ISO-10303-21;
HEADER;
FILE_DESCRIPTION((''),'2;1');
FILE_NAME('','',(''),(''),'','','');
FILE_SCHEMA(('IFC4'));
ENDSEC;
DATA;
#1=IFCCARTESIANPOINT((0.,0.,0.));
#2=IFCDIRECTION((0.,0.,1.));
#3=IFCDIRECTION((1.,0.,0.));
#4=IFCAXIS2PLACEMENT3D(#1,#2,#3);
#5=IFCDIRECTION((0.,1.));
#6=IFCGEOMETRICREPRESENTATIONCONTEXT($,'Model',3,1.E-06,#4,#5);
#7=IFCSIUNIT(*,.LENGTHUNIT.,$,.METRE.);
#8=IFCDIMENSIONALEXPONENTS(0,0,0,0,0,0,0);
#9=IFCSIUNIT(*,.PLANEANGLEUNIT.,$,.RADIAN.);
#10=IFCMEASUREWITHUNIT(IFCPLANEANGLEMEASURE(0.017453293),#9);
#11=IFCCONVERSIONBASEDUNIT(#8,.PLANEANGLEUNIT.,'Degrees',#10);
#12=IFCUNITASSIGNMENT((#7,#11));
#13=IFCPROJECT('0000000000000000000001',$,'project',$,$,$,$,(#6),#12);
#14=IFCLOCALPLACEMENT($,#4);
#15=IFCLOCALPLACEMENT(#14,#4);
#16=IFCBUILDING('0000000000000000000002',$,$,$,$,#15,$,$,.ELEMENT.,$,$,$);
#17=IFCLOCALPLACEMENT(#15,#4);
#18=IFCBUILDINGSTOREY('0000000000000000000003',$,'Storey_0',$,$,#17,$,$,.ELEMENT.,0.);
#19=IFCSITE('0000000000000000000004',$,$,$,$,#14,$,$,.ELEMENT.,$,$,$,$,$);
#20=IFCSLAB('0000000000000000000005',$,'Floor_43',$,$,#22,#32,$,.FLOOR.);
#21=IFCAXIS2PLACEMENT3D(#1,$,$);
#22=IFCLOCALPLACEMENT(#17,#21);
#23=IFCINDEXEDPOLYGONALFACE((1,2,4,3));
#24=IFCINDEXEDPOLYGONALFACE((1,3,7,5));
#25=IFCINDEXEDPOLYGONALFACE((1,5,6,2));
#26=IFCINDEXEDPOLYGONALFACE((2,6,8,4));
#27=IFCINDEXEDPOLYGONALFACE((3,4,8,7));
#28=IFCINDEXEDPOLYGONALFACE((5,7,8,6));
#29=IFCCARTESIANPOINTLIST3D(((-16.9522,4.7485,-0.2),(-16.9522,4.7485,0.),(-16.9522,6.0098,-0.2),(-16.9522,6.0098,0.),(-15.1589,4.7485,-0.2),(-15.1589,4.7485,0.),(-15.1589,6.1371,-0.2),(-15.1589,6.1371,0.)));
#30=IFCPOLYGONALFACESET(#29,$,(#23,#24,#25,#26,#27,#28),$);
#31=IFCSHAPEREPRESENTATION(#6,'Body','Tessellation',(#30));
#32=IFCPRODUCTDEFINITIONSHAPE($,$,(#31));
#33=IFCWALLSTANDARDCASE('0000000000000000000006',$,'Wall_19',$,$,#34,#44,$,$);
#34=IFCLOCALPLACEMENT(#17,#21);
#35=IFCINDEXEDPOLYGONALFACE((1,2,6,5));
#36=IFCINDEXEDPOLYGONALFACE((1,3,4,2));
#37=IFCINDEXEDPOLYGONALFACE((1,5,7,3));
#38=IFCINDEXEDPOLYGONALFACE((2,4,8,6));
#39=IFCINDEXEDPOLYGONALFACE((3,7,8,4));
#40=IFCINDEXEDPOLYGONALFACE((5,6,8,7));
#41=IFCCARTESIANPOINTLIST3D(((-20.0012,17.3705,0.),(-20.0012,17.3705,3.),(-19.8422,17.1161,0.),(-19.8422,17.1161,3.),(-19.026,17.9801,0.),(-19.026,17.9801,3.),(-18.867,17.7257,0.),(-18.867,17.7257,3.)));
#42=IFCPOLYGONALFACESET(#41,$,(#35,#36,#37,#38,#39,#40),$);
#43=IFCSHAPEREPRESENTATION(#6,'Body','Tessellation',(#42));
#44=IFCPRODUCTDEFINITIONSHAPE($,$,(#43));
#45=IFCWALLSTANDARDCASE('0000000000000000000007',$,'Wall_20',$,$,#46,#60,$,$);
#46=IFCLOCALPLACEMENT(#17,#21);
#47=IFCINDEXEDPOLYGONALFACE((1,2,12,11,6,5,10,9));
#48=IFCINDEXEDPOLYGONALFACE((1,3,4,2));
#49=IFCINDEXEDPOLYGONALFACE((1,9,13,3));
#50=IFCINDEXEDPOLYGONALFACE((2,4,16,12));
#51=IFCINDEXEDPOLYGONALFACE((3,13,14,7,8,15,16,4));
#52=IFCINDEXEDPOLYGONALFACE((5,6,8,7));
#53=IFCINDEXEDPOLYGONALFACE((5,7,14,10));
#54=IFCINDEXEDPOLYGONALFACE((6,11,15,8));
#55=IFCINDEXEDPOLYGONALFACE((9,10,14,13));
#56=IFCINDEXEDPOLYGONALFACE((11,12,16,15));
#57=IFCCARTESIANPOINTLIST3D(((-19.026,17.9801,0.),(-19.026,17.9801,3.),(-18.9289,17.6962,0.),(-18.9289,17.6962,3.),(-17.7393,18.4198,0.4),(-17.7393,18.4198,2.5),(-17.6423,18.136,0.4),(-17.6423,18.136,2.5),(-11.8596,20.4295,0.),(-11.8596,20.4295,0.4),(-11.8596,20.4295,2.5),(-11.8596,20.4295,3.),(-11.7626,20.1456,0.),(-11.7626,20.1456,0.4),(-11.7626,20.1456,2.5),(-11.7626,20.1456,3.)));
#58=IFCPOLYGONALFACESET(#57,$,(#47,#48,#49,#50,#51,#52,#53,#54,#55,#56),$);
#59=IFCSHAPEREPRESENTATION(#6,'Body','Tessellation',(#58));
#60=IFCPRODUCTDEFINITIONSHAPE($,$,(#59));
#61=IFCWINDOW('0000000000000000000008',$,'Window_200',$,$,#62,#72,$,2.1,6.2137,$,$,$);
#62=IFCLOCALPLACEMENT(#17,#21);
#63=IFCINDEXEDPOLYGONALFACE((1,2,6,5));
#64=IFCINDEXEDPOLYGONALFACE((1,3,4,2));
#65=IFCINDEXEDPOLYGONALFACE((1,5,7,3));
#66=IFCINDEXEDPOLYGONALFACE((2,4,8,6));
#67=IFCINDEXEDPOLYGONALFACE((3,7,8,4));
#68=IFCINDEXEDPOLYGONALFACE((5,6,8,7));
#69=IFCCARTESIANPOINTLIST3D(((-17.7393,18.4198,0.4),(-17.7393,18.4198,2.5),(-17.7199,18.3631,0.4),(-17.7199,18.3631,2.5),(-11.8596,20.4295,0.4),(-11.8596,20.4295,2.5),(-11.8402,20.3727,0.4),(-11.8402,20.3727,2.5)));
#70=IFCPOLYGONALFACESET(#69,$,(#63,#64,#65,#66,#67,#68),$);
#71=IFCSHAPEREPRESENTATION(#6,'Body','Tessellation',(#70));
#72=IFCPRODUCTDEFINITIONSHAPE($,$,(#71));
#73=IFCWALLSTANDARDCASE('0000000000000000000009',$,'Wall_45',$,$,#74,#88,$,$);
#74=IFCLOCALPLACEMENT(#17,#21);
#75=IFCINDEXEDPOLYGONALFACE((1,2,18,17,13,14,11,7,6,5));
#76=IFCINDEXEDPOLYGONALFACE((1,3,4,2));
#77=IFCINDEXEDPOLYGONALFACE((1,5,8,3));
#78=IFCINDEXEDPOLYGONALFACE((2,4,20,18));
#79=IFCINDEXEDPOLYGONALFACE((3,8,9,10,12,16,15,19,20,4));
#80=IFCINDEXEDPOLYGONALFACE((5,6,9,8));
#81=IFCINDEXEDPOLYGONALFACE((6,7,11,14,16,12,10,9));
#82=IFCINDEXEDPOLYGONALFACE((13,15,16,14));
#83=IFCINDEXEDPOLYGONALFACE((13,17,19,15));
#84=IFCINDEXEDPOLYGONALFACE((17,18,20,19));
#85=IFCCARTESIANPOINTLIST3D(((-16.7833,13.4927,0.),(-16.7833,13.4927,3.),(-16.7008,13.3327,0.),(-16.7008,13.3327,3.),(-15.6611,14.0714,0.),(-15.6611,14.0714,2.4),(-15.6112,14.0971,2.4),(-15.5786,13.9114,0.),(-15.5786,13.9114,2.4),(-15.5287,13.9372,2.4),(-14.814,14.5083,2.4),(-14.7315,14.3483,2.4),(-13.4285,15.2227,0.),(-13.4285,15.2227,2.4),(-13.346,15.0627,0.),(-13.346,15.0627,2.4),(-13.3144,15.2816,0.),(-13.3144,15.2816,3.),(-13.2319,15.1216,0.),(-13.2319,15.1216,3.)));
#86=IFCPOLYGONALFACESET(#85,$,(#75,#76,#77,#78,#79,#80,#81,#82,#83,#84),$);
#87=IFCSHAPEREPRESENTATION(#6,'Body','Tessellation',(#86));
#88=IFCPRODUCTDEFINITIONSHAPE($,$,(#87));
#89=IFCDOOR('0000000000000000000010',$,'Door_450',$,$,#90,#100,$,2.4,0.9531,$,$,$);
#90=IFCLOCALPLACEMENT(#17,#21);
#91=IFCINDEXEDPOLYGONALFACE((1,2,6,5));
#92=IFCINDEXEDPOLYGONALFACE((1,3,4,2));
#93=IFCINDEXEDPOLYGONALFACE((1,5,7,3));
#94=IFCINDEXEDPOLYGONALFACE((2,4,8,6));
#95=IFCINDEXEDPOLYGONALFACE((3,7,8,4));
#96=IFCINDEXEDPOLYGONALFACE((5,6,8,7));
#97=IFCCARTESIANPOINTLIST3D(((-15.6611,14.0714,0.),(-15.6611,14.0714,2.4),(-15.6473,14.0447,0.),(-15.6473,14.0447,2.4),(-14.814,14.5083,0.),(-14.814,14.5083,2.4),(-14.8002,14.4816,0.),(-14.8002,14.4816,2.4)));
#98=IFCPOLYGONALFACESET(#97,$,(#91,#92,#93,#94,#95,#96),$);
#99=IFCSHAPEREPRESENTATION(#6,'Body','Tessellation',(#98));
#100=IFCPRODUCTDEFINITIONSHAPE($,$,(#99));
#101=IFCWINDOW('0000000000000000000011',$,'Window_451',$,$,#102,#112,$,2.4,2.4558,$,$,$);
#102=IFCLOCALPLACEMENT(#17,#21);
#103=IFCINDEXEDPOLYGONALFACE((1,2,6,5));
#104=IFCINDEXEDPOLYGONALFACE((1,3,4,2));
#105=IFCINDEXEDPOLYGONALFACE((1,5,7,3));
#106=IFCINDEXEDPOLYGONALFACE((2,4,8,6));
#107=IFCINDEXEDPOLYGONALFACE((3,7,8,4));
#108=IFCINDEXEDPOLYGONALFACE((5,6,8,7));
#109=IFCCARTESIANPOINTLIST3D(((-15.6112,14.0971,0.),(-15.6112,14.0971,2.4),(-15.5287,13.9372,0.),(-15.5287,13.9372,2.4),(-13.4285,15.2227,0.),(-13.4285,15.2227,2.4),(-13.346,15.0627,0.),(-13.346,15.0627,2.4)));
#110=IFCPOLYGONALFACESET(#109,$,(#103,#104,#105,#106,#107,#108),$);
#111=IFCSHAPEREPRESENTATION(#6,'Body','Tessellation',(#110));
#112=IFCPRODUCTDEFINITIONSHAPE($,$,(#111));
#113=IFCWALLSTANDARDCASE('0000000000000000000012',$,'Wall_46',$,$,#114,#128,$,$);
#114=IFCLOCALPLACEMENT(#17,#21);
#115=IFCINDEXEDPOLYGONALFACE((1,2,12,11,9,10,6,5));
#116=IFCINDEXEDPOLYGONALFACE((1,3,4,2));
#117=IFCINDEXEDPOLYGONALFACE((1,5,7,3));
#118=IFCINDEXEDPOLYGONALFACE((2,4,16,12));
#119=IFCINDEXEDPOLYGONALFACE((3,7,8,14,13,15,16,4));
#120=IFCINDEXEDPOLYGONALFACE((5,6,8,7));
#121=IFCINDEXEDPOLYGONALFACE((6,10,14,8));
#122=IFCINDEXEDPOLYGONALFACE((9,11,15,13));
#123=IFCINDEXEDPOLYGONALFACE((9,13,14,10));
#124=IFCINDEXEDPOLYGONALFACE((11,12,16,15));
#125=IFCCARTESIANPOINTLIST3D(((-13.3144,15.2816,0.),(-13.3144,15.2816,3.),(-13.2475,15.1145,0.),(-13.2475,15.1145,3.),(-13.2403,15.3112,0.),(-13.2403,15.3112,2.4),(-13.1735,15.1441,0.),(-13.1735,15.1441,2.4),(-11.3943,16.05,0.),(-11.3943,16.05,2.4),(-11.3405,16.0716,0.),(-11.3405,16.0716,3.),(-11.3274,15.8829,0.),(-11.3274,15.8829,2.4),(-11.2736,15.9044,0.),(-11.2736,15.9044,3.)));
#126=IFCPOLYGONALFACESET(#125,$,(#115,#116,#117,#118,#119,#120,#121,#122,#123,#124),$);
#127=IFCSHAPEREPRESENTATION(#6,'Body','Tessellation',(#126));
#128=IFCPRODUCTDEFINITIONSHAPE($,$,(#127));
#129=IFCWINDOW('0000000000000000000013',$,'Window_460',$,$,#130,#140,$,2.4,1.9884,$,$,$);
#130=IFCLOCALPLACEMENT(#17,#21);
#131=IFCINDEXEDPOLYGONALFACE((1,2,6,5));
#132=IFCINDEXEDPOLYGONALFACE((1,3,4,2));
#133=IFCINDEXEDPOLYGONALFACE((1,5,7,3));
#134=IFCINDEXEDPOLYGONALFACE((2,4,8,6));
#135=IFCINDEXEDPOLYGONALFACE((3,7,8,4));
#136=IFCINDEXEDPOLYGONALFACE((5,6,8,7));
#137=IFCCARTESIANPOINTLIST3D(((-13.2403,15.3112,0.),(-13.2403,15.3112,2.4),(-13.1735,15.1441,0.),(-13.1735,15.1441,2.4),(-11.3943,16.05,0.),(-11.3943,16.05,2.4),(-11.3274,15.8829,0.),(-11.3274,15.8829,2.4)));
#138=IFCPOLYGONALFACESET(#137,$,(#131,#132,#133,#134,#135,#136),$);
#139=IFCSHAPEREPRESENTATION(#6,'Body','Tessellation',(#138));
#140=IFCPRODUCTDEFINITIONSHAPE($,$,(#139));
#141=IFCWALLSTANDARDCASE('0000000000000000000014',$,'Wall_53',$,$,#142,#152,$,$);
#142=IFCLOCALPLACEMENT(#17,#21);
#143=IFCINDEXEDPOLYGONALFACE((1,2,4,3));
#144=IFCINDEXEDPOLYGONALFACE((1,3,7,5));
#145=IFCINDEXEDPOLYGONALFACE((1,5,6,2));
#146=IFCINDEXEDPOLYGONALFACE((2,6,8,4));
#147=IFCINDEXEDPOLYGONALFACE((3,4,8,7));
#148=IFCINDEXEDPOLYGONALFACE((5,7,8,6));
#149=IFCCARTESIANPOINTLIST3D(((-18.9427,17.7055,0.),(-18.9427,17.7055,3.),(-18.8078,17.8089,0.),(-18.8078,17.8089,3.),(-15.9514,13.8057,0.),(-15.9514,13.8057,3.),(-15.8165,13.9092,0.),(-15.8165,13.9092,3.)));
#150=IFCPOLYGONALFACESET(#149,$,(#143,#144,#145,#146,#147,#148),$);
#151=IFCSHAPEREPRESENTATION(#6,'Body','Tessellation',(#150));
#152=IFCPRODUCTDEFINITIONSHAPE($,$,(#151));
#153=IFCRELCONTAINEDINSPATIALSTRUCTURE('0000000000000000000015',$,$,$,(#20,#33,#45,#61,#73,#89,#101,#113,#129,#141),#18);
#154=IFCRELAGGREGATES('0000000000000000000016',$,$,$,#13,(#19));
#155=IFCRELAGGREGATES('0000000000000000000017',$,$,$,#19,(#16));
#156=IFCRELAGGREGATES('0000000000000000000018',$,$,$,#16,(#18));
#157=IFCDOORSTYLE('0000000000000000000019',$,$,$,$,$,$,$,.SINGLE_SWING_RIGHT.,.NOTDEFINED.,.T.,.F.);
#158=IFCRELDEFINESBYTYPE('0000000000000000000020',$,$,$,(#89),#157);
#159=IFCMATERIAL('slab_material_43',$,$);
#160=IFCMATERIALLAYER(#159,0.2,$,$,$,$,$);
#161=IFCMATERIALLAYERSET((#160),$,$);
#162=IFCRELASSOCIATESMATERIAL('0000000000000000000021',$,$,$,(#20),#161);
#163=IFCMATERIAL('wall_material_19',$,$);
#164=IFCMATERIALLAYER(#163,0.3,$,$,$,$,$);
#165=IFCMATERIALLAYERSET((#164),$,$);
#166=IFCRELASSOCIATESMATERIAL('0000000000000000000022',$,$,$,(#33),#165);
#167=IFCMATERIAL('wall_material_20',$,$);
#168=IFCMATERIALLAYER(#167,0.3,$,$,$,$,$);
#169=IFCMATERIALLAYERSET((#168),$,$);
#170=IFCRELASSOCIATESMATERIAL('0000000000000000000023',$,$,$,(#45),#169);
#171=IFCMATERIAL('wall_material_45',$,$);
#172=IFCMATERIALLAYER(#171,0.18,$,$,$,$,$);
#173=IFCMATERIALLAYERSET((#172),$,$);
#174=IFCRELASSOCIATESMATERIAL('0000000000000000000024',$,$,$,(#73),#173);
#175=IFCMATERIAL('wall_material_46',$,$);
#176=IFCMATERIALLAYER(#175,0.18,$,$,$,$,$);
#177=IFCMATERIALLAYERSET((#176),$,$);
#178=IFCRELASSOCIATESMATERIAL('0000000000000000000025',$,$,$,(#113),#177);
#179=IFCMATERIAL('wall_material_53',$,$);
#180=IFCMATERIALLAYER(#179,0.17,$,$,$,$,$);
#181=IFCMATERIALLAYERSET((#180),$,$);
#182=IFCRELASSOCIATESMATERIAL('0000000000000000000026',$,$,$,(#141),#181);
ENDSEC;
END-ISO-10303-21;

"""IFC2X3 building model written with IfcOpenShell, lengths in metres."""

from ifc_helpers import new_model, entity, si_unit, converted_unit, direction, frame, frame_2d, origin_with_axes, place, context, project, spatial, polyline, rectangle, outline, extrude, material, layer, layer_set, layer_usage, type_object, element, fill, save


model = new_model("IFC2X3")

# Units and contexts
model_context = context("Model", 3, precision=1e-06, world=origin_with_axes(), true_north=direction((0.0, 1.0)))
ifc_project = project(units=[si_unit("LENGTHUNIT", "METRE"), converted_unit("PLANEANGLEUNIT", "Degrees", entity("IfcPlaneAngleMeasure", 0.017453293), si_unit("PLANEANGLEUNIT", "RADIAN"), dimensions=[0, 0, 0, 0, 0, 0, 0])], contexts=[model_context])

# Site, building, storey
site_placement = place(None, origin_with_axes())
site = spatial("IfcSite", under=ifc_project, at=site_placement, CompositionType="ELEMENT")
building_placement = place(site_placement, origin_with_axes())
building = spatial("IfcBuilding", under=site, at=building_placement, CompositionType="ELEMENT")
storey_placement = place(building_placement, origin_with_axes())
storey = spatial("IfcBuildingStorey", under=building, at=storey_placement, Name="Storey_0", CompositionType="ELEMENT", Elevation=0.0)

# Slab
ifc_material_1 = material(Name="slab_material_43")
ifc_layer_1 = layer(ifc_material_1, 0.2)
ifc_layer_set_1 = layer_set([ifc_layer_1])
ifc_layer_usage_1 = layer_usage(ifc_layer_set_1, "AXIS3", "POSITIVE", 0.0)
slab_1_placement = place(storey_placement, frame((-16.0556, 5.4428, -0.2), z_axis=(0.0, 0.0, 1.0), x_axis=(1.0, 0.0, 0.0)))
element("IfcSlab", 1, at=slab_1_placement, inside=storey, material=ifc_layer_usage_1, Name="Floor_43", PredefinedType="FLOOR", context=model_context, shape_type="SweptSolid", body=[
    extrude(outline(polyline([(0.8967, -0.6943), (-0.8967, -0.6943), (-0.8967, 0.567), (0.8967, 0.6943), (0.8967, -0.6943)])), origin_with_axes(), (0.0, 0.0, 1.0), 0.2),
])

# Wall
ifc_material_2 = material(Name="wall_material_19")
ifc_layer_2 = layer(ifc_material_2, 0.3)
ifc_layer_set_2 = layer_set([ifc_layer_2])
ifc_layer_usage_2 = layer_usage(ifc_layer_set_2, "AXIS2", "NEGATIVE", 0.0)
wall_1_placement = place(storey_placement, frame((-20.0012, 17.3705, 0.0), z_axis=(0.0, 0.0, 1.0), x_axis=(0.847956, 0.530067, 0.0)))
element("IfcWallStandardCase", 2, at=wall_1_placement, inside=storey, material=ifc_layer_usage_2, Name="Wall_19", context=model_context, shape_type="SweptSolid", body=[
    extrude(outline(polyline([(0.0, 0.0), (1.1501, 0.0), (1.1501, -0.3), (0.0, -0.3), (0.0, 0.0)])), origin_with_axes(), (0.0, 0.0, 1.0), 3.0),
])

# Wall, opening, window
ifc_material_3 = material(Name="wall_material_20")
ifc_layer_3 = layer(ifc_material_3, 0.3)
ifc_layer_set_3 = layer_set([ifc_layer_3])
ifc_layer_usage_3 = layer_usage(ifc_layer_set_3, "AXIS2", "NEGATIVE", 0.0)
wall_2_placement = place(storey_placement, frame((-19.026, 17.9801, 0.0), z_axis=(0.0, 0.0, 1.0), x_axis=(0.946255, 0.323422, 0.0)))
wall_2 = element("IfcWallStandardCase", 3, at=wall_2_placement, inside=storey, material=ifc_layer_usage_3, Name="Wall_20", context=model_context, shape_type="SweptSolid", body=[
    extrude(outline(polyline([(0.0, 0.0), (7.5734, 0.0), (7.5734, -0.3), (0.0, -0.3), (0.0, 0.0)])), origin_with_axes(), (0.0, 0.0, 1.0), 3.0),
])
opening_1_placement = place(wall_2_placement, frame((1.3597, 0.0, 0.4), z_axis=(0.0, 0.0, 1.0), x_axis=(1.0, 0.0, 0.0)))
opening_1 = element("IfcOpeningElement", 4, at=opening_1_placement, cuts=wall_2, context=model_context, shape_type="SweptSolid", body=[
    extrude(rectangle(XDim=6.2137, YDim=2.1, at=frame_2d((1.05, -3.1069), x_axis=(0.0, 1.0))), frame((0.0, 0.01, 0.0), z_axis=(0.0, -1.0, 0.0), x_axis=(0.0, 0.0, 1.0)), (0.0, 0.0, 1.0), 0.32),
])
window_1_placement = place(storey_placement, frame((0.0, 0.0, 0.4), z_axis=(0.0, 0.0, 1.0), x_axis=(1.0, 0.0, 0.0)))
window_1 = element("IfcWindow", 5, at=window_1_placement, inside=storey, Name="Window_200", OverallHeight=2.1, OverallWidth=6.2137, context=model_context, shape_type="SweptSolid", body=[
    extrude(outline(polyline([(-17.7393, 18.4198), (-11.8596, 20.4295), (-11.8402, 20.3727), (-17.7199, 18.3631), (-17.7393, 18.4198)])), origin_with_axes(), (0.0, 0.0, 1.0), 2.1),
])
fill(opening_1, window_1)

# Wall, openings, door, window
ifc_material_4 = material(Name="wall_material_45")
ifc_layer_4 = layer(ifc_material_4, 0.18)
ifc_layer_set_4 = layer_set([ifc_layer_4])
ifc_layer_usage_4 = layer_usage(ifc_layer_set_4, "AXIS2", "POSITIVE", 0.0)
wall_3_placement = place(storey_placement, frame((-16.7008, 13.3327, 0.0), z_axis=(0.0, 0.0, 1.0), x_axis=(0.888777, 0.458339, 0.0)))
wall_3 = element("IfcWallStandardCase", 6, at=wall_3_placement, inside=storey, material=ifc_layer_usage_4, Name="Wall_45", context=model_context, shape_type="SweptSolid", body=[
    extrude(outline(polyline([(0.0, 0.18), (3.903, 0.18), (3.903, 0.0), (0.0, 0.0), (0.0, 0.18)])), origin_with_axes(), (0.0, 0.0, 1.0), 3.0),
])
opening_2_placement = place(wall_3_placement, frame((1.2627, 0.18, 0.0), z_axis=(0.0, 0.0, 1.0), x_axis=(1.0, 0.0, 0.0)))
opening_2 = element("IfcOpeningElement", 7, at=opening_2_placement, cuts=wall_3, context=model_context, shape_type="SweptSolid", body=[
    extrude(rectangle(XDim=0.9531, YDim=2.4, at=frame_2d((1.2, -0.4766), x_axis=(0.0, 1.0))), frame((0.0, 0.01, 0.0), z_axis=(0.0, -1.0, 0.0), x_axis=(0.0, 0.0, 1.0)), (0.0, 0.0, 1.0), 0.2),
])
opening_3_placement = place(wall_3_placement, frame((1.3188, 0.18, 0.0), z_axis=(0.0, 0.0, 1.0), x_axis=(1.0, 0.0, 0.0)))
opening_3 = element("IfcOpeningElement", 8, at=opening_3_placement, cuts=wall_3, context=model_context, shape_type="SweptSolid", body=[
    extrude(rectangle(XDim=2.4558, YDim=2.4, at=frame_2d((1.2, -1.2279), x_axis=(0.0, 1.0))), frame((0.0, 0.01, 0.0), z_axis=(0.0, -1.0, 0.0), x_axis=(0.0, 0.0, 1.0)), (0.0, 0.0, 1.0), 0.2),
])
door_style_1 = type_object("IfcDoorStyle", ConstructionType="NOTDEFINED", OperationType="SINGLE_SWING_RIGHT", ParameterTakesPrecedence=True, Sizeable=False)
door_1_placement = place(storey_placement, origin_with_axes())
door_1 = element("IfcDoor", 9, at=door_1_placement, inside=storey, type_object=door_style_1, Name="Door_450", OverallHeight=2.4, OverallWidth=0.9531, context=model_context, shape_type="SweptSolid", body=[
    extrude(outline(polyline([(-15.6611, 14.0714), (-14.814, 14.5083), (-14.8002, 14.4816), (-15.6473, 14.0447), (-15.6611, 14.0714)])), origin_with_axes(), (0.0, 0.0, 1.0), 2.4),
])
fill(opening_2, door_1)
window_2_placement = place(storey_placement, origin_with_axes())
window_2 = element("IfcWindow", 10, at=window_2_placement, inside=storey, Name="Window_451", OverallHeight=2.4, OverallWidth=2.4558, context=model_context, shape_type="SweptSolid", body=[
    extrude(outline(polyline([(-15.6112, 14.0971), (-13.4285, 15.2227), (-13.346, 15.0627), (-15.5287, 13.9372), (-15.6112, 14.0971)])), origin_with_axes(), (0.0, 0.0, 1.0), 2.4),
])
fill(opening_3, window_2)

# Wall, opening, window
ifc_material_5 = material(Name="wall_material_46")
ifc_layer_5 = layer(ifc_material_5, 0.18)
ifc_layer_set_5 = layer_set([ifc_layer_5])
ifc_layer_usage_5 = layer_usage(ifc_layer_set_5, "AXIS2", "POSITIVE", 0.0)
wall_4_placement = place(storey_placement, frame((-13.2475, 15.1145, 0.0), z_axis=(0.0, 0.0, 1.0), x_axis=(0.92841, 0.371557, 0.0)))
wall_4 = element("IfcWallStandardCase", 11, at=wall_4_placement, inside=storey, material=ifc_layer_usage_5, Name="Wall_46", context=model_context, shape_type="SweptSolid", body=[
    extrude(outline(polyline([(0.0, 0.18), (2.1261, 0.18), (2.1261, 0.0), (0.0, 0.0), (0.0, 0.18)])), origin_with_axes(), (0.0, 0.0, 1.0), 3.0),
])
opening_4_placement = place(wall_4_placement, frame((0.0798, 0.18, 0.0), z_axis=(0.0, 0.0, 1.0), x_axis=(1.0, 0.0, 0.0)))
opening_4 = element("IfcOpeningElement", 12, at=opening_4_placement, cuts=wall_4, context=model_context, shape_type="SweptSolid", body=[
    extrude(rectangle(XDim=1.9884, YDim=2.4, at=frame_2d((1.2, -0.9942), x_axis=(0.0, 1.0))), frame((0.0, 0.01, 0.0), z_axis=(0.0, -1.0, 0.0), x_axis=(0.0, 0.0, 1.0)), (0.0, 0.0, 1.0), 0.2),
])
window_3_placement = place(storey_placement, origin_with_axes())
window_3 = element("IfcWindow", 13, at=window_3_placement, inside=storey, Name="Window_460", OverallHeight=2.4, OverallWidth=1.9884, context=model_context, shape_type="SweptSolid", body=[
    extrude(outline(polyline([(-13.2403, 15.3112), (-11.3943, 16.05), (-11.3274, 15.8829), (-13.1735, 15.1441), (-13.2403, 15.3112)])), origin_with_axes(), (0.0, 0.0, 1.0), 2.4),
])
fill(opening_4, window_3)

# Wall
ifc_material_6 = material(Name="wall_material_53")
ifc_layer_6 = layer(ifc_material_6, 0.17)
ifc_layer_set_6 = layer_set([ifc_layer_6])
ifc_layer_usage_6 = layer_usage(ifc_layer_set_6, "AXIS2", "NEGATIVE", 0.0)
wall_5_placement = place(storey_placement, frame((-18.8078, 17.8089, 0.0), z_axis=(0.0, 0.0, 1.0), x_axis=(0.608623, -0.79346, 0.0)))
element("IfcWallStandardCase", 14, at=wall_5_placement, inside=storey, material=ifc_layer_usage_6, Name="Wall_53", context=model_context, shape_type="SweptSolid", body=[
    extrude(outline(polyline([(0.0, 0.0), (4.9148, 0.0), (4.9148, -0.17), (0.0, -0.17), (0.0, 0.0)])), origin_with_axes(), (0.0, 0.0, 1.0), 3.0),
])

save(model, "model.ifc")
